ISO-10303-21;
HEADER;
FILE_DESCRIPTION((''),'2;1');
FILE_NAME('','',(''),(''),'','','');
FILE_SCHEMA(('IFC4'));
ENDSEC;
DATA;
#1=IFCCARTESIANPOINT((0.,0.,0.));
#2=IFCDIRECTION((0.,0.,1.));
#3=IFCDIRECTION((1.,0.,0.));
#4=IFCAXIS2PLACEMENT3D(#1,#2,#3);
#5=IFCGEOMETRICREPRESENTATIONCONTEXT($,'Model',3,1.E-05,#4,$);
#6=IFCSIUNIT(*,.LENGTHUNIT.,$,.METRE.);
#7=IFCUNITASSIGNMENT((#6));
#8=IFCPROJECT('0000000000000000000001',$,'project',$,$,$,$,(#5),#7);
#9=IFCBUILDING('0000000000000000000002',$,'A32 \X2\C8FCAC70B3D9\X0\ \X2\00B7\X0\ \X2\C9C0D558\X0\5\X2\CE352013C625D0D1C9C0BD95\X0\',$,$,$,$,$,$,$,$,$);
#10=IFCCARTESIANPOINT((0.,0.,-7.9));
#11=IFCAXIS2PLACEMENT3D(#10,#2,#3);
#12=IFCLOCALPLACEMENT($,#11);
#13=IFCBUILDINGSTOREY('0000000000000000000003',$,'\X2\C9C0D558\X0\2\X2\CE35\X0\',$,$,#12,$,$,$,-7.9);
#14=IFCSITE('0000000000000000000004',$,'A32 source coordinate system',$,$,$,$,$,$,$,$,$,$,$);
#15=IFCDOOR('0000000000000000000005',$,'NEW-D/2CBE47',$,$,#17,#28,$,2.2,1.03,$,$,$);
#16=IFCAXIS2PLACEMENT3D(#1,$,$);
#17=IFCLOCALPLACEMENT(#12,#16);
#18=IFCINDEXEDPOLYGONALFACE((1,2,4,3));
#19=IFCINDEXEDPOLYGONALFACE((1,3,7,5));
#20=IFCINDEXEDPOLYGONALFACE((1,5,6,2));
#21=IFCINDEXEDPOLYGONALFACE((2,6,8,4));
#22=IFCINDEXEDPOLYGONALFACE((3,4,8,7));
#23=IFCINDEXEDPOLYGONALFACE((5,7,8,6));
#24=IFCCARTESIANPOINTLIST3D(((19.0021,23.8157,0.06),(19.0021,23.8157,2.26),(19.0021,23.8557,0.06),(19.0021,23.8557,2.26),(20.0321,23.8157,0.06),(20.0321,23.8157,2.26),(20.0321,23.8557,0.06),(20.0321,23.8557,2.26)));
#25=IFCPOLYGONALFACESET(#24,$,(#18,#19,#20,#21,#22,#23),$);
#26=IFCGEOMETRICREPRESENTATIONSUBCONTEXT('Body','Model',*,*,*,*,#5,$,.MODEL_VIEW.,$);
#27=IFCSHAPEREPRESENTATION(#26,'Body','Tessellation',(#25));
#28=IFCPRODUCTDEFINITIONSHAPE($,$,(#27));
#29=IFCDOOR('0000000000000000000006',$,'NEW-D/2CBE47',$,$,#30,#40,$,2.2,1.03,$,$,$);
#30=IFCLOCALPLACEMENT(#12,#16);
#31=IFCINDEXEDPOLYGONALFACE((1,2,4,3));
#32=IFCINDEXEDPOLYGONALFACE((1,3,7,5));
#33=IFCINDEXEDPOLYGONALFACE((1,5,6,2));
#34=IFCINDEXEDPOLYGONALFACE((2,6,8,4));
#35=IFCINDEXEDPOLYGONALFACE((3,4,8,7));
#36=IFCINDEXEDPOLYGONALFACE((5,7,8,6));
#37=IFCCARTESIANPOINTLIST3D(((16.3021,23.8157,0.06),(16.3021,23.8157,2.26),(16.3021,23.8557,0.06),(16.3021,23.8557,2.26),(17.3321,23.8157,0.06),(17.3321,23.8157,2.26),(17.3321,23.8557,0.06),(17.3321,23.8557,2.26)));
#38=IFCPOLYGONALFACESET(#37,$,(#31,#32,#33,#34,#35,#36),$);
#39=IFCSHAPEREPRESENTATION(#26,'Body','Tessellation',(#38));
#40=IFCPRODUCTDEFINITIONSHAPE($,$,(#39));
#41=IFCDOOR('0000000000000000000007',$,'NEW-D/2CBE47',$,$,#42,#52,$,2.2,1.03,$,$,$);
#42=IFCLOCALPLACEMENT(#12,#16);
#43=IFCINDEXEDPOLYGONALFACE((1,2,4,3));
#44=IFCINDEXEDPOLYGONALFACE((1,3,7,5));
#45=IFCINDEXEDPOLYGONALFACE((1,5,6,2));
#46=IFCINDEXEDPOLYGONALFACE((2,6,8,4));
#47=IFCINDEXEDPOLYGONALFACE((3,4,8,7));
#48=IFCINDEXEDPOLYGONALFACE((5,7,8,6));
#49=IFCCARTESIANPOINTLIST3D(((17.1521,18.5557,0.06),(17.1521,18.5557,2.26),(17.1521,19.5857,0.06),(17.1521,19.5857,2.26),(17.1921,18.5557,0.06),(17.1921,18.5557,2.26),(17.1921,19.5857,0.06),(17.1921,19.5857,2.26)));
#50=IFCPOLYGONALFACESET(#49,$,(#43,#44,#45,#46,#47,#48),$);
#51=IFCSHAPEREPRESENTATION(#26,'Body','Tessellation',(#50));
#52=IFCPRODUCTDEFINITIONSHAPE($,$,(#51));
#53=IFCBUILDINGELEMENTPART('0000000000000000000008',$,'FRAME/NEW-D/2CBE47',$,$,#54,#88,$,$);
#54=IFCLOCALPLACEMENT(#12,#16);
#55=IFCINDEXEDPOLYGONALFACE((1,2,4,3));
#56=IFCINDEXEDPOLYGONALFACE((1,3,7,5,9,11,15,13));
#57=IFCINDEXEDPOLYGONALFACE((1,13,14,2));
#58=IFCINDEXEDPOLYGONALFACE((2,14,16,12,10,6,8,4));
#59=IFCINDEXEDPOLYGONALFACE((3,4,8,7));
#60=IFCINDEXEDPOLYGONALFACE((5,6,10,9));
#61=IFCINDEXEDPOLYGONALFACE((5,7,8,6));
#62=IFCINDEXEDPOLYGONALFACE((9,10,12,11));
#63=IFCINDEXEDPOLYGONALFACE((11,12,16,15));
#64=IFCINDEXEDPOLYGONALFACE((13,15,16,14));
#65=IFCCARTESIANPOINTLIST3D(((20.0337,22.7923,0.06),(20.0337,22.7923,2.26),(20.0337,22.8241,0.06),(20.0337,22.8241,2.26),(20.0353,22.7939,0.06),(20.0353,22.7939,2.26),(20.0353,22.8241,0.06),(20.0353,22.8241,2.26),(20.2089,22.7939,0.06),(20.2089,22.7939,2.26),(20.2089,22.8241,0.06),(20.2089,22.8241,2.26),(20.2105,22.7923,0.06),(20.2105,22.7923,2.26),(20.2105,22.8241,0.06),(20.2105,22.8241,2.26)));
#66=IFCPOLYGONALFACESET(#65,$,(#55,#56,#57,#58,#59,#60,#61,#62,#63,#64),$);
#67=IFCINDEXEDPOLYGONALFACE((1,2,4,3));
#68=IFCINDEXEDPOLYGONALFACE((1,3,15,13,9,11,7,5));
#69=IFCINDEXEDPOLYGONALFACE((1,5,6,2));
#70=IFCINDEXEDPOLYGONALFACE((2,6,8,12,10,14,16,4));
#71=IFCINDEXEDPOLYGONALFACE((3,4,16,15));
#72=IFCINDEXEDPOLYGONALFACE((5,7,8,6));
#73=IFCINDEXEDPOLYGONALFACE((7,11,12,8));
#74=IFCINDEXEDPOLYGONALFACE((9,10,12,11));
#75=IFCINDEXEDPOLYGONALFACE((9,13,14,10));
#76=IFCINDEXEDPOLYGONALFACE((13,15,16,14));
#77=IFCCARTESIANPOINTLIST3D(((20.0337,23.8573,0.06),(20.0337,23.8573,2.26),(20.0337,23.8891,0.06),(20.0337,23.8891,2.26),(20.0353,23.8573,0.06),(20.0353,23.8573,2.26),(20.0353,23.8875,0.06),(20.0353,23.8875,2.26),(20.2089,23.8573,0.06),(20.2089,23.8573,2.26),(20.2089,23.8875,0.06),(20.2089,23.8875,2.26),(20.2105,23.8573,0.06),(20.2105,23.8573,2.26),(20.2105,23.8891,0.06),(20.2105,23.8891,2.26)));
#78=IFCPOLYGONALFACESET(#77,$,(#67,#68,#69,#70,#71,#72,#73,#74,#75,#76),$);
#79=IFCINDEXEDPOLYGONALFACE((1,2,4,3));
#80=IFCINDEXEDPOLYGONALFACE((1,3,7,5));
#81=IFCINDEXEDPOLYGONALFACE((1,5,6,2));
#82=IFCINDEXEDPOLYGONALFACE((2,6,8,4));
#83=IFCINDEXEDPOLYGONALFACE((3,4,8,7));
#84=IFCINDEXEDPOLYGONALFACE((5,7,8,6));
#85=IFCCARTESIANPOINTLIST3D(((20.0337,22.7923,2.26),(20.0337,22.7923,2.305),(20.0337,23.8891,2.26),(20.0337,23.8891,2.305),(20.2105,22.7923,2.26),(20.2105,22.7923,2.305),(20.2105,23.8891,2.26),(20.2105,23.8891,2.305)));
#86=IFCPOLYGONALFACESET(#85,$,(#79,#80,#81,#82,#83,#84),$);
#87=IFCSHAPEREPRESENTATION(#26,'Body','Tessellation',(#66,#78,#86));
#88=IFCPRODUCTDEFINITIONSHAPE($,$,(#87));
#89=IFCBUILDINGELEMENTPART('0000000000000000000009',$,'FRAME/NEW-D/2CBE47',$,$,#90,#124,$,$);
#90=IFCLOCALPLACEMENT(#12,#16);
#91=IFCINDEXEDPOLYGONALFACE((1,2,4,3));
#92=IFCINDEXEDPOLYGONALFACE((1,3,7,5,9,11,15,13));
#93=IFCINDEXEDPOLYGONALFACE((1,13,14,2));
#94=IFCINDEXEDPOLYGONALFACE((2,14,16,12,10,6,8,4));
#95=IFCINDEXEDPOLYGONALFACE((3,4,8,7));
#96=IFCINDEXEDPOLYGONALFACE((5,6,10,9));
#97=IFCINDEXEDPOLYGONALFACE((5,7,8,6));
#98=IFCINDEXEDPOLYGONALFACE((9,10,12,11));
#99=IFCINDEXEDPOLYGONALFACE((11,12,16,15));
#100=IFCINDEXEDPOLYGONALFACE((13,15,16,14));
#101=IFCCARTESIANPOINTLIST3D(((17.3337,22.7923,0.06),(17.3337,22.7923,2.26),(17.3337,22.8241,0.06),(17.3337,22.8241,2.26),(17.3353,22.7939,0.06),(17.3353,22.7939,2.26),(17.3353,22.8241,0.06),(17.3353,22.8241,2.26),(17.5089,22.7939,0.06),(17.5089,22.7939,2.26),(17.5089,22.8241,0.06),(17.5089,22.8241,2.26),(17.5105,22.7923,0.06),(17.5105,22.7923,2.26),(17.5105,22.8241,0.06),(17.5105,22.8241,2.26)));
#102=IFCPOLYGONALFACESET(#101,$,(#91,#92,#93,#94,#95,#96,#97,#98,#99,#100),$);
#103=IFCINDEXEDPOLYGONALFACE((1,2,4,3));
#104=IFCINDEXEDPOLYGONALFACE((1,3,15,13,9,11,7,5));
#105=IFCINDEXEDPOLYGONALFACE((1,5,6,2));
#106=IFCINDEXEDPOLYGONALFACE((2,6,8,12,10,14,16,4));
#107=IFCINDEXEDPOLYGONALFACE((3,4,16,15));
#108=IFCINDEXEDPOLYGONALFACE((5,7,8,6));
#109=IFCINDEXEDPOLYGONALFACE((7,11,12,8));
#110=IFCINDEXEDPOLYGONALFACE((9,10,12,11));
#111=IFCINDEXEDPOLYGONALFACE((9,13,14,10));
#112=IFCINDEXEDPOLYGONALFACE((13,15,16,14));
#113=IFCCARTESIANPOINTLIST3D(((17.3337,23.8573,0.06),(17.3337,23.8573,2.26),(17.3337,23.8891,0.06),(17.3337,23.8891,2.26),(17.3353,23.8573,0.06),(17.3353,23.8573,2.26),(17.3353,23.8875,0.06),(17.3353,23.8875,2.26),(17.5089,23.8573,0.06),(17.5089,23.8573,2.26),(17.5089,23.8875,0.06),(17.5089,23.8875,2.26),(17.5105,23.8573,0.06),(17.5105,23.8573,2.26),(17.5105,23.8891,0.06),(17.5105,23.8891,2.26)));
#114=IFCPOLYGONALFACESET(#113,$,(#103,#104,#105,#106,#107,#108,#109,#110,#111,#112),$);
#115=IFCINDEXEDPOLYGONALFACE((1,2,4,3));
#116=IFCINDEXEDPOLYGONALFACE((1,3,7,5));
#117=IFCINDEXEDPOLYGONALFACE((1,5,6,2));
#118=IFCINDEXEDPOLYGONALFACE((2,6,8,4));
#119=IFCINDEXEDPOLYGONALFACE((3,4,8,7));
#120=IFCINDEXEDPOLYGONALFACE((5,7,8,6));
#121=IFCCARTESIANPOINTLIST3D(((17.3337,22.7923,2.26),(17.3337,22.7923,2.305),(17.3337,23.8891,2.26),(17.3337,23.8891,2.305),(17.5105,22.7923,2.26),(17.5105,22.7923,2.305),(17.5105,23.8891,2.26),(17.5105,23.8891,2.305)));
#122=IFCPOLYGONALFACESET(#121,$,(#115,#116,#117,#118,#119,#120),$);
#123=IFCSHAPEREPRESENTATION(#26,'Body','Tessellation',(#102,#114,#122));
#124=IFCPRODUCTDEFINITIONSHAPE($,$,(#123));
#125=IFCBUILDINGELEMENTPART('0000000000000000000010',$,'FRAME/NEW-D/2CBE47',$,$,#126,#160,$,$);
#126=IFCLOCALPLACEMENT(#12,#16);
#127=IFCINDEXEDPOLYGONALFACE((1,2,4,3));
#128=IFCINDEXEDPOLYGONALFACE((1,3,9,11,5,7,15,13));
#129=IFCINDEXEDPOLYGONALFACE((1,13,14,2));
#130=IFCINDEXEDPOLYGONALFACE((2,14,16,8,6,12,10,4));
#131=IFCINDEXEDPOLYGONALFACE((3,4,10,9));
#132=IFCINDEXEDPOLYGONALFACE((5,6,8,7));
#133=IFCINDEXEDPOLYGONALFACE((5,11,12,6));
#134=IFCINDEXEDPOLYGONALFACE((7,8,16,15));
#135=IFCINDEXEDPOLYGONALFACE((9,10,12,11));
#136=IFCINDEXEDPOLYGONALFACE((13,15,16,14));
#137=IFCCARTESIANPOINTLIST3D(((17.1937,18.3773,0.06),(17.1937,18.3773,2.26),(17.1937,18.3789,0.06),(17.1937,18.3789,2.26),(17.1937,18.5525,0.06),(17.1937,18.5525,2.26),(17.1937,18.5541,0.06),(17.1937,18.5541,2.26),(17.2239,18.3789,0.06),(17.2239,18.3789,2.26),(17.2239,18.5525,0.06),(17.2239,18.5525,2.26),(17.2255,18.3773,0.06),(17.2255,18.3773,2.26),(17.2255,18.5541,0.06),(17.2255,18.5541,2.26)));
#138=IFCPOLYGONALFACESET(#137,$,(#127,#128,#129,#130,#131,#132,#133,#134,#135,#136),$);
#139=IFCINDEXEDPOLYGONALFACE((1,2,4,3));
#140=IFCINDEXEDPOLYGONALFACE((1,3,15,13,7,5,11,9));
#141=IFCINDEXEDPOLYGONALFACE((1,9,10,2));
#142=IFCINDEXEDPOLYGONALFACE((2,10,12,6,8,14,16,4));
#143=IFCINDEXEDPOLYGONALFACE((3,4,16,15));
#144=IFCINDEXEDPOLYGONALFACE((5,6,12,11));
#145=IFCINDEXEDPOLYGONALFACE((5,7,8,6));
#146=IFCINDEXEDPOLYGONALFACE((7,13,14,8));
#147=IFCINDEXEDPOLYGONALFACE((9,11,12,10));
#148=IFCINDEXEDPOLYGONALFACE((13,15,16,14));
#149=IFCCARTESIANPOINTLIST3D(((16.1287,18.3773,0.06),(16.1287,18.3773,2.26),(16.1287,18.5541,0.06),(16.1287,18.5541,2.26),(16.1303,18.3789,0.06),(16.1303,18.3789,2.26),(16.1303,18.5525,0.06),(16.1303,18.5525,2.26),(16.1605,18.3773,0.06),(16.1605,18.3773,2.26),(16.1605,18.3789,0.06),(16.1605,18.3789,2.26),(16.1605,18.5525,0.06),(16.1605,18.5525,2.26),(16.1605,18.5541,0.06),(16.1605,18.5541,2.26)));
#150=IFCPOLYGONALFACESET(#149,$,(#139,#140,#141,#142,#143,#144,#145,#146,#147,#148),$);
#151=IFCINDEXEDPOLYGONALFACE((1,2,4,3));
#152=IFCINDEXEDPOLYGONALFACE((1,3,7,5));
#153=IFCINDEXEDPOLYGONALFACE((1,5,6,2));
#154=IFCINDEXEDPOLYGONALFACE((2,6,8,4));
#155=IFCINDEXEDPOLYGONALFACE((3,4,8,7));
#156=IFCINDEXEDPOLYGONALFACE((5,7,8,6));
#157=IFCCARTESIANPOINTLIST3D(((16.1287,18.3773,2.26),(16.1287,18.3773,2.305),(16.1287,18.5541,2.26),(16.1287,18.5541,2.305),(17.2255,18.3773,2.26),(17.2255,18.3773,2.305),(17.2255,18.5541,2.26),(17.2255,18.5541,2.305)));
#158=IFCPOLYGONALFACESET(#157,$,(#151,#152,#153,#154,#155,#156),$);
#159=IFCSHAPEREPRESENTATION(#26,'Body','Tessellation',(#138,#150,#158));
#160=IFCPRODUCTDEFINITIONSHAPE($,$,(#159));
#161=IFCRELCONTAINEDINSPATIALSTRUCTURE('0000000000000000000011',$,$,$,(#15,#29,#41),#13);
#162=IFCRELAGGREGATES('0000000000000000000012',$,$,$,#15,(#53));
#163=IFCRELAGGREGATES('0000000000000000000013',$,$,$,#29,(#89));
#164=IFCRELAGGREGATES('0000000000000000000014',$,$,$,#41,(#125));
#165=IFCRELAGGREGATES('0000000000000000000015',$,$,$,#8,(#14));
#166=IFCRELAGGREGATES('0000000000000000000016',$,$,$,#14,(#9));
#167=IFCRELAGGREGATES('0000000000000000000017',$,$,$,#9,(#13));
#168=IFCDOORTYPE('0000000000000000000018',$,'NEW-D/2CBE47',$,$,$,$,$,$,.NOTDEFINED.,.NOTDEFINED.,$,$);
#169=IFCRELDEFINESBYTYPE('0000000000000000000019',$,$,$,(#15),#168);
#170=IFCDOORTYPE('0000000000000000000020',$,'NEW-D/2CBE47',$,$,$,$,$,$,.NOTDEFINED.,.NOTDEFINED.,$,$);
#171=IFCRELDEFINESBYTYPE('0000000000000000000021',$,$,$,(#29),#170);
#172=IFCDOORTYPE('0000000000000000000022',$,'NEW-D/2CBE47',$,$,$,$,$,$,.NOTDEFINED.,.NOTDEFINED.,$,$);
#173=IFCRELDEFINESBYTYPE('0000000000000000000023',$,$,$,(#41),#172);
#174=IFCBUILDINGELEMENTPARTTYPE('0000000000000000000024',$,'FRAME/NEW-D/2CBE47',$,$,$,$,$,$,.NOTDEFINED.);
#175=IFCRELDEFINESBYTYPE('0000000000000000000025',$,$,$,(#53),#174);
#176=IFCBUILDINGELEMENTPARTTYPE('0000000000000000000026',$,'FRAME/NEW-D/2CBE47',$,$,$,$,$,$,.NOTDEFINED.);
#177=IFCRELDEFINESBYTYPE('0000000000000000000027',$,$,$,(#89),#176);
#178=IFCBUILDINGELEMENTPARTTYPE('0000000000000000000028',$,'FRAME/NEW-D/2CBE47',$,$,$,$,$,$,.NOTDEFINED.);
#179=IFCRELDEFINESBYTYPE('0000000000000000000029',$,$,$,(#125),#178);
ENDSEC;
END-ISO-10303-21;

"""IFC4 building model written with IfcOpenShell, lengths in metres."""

from ifc_helpers import new_model, si_unit, frame, origin, origin_with_axes, place, context, subcontext, project, spatial, polyline, outline, extrude, source, transform, mapped, type_object, type_shapes, element, aggregate, save


model = new_model("IFC4")

# Units and contexts
model_context = context("Model", 3, precision=1e-05, world=origin_with_axes())
body_context = subcontext(model_context, "Body", "Model", "MODEL_VIEW")
ifc_project = project(units=[si_unit("LENGTHUNIT", "METRE")], contexts=[model_context])

# Site, building, storey
site = spatial("IfcSite", under=ifc_project, Name="A32 source coordinate system")
building = spatial("IfcBuilding", under=site, Name="A32 주거동 · 지하5층–옥탑지붕")
storey_placement = place(None, frame((0.0, 0.0, -7.9), z_axis=(0.0, 0.0, 1.0), x_axis=(1.0, 0.0, 0.0)))
storey = spatial("IfcBuildingStorey", under=building, at=storey_placement, Name="지하2층", Elevation=-7.9)

# Doors
door_type_1 = type_object("IfcDoorType", Name="NEW-D/2CBE47", OperationType="NOTDEFINED", PredefinedType="NOTDEFINED")
shared_shape_1 = source(origin(), body_context, "Body", "SweptSolid", [
    extrude(outline(polyline([(20.0321, 23.8557), (20.0321, 23.8157), (19.0021, 23.8157), (19.0021, 23.8557), (20.0321, 23.8557)])), frame((0.0, 0.0, 0.06)), (0.0, 0.0, 1.0), 2.2),
])
type_shapes(door_type_1, [shared_shape_1])
door_1_placement = place(storey_placement, origin_with_axes())
door_1 = element("IfcDoor", 1, at=door_1_placement, inside=storey, type_object=door_type_1, Name="NEW-D/2CBE47", OverallHeight=2.2, OverallWidth=1.03, context=body_context, shape_type="MappedRepresentation", body=[
    mapped(shared_shape_1, transform((0.0, 0.0, 0.0), scale=1.0)),
])
door_type_2 = type_object("IfcDoorType", Name="NEW-D/2CBE47", OperationType="NOTDEFINED", PredefinedType="NOTDEFINED")
shared_shape_2 = source(origin(), body_context, "Body", "SweptSolid", [
    extrude(outline(polyline([(17.3321, 23.8557), (17.3321, 23.8157), (16.3021, 23.8157), (16.3021, 23.8557), (17.3321, 23.8557)])), frame((0.0, 0.0, 0.06)), (0.0, 0.0, 1.0), 2.2),
])
type_shapes(door_type_2, [shared_shape_2])
door_2_placement = place(storey_placement, origin_with_axes())
door_2 = element("IfcDoor", 2, at=door_2_placement, inside=storey, type_object=door_type_2, Name="NEW-D/2CBE47", OverallHeight=2.2, OverallWidth=1.03, context=body_context, shape_type="MappedRepresentation", body=[
    mapped(shared_shape_2, transform((0.0, 0.0, 0.0), scale=1.0)),
])
door_type_3 = type_object("IfcDoorType", Name="NEW-D/2CBE47", OperationType="NOTDEFINED", PredefinedType="NOTDEFINED")
shared_shape_3 = source(origin(), body_context, "Body", "SweptSolid", [
    extrude(outline(polyline([(17.1921, 18.5557), (17.1521, 18.5557), (17.1521, 19.5857), (17.1921, 19.5857), (17.1921, 18.5557)])), frame((0.0, 0.0, 0.06)), (0.0, 0.0, 1.0), 2.2),
])
type_shapes(door_type_3, [shared_shape_3])
door_3_placement = place(storey_placement, origin_with_axes())
door_3 = element("IfcDoor", 3, at=door_3_placement, inside=storey, type_object=door_type_3, Name="NEW-D/2CBE47", OverallHeight=2.2, OverallWidth=1.03, context=body_context, shape_type="MappedRepresentation", body=[
    mapped(shared_shape_3, transform((0.0, 0.0, 0.0), scale=1.0)),
])

# Building element parts
building_element_part_type_1 = type_object("IfcBuildingElementPartType", Name="FRAME/NEW-D/2CBE47", PredefinedType="NOTDEFINED")
shared_shape_4 = source(origin(), body_context, "Body", "SweptSolid", [
    extrude(outline(polyline([(20.0353, 22.7939), (20.2089, 22.7939), (20.2089, 22.8241), (20.2105, 22.8241), (20.2105, 22.7923), (20.0337, 22.7923), (20.0337, 22.8241), (20.0353, 22.8241), (20.0353, 22.7939)])), frame((0.0, 0.0, 0.06)), (0.0, 0.0, 1.0), 2.2),
    extrude(outline(polyline([(20.2105, 23.8891), (20.2105, 23.8573), (20.2089, 23.8573), (20.2089, 23.8875), (20.0353, 23.8875), (20.0353, 23.8573), (20.0337, 23.8573), (20.0337, 23.8891), (20.2105, 23.8891)])), frame((0.0, 0.0, 0.06)), (0.0, 0.0, 1.0), 2.2),
    extrude(outline(polyline([(20.2105, 22.7923), (20.2105, 23.8891), (20.0337, 23.8891), (20.0337, 22.7923), (20.2105, 22.7923)])), frame((0.0, 0.0, 2.26)), (0.0, 0.0, 1.0), 0.045),
])
type_shapes(building_element_part_type_1, [shared_shape_4])
building_element_part_1_placement = place(door_1_placement, origin_with_axes())
building_element_part_1 = element("IfcBuildingElementPart", 4, at=building_element_part_1_placement, type_object=building_element_part_type_1, Name="FRAME/NEW-D/2CBE47", context=body_context, shape_type="MappedRepresentation", body=[
    mapped(shared_shape_4, transform((0.0, 0.0, 0.0), scale=1.0)),
])
aggregate(door_1, [building_element_part_1])
building_element_part_type_2 = type_object("IfcBuildingElementPartType", Name="FRAME/NEW-D/2CBE47", PredefinedType="NOTDEFINED")
shared_shape_5 = source(origin(), body_context, "Body", "SweptSolid", [
    extrude(outline(polyline([(17.3353, 22.7939), (17.5089, 22.7939), (17.5089, 22.8241), (17.5105, 22.8241), (17.5105, 22.7923), (17.3337, 22.7923), (17.3337, 22.8241), (17.3353, 22.8241), (17.3353, 22.7939)])), frame((0.0, 0.0, 0.06)), (0.0, 0.0, 1.0), 2.2),
    extrude(outline(polyline([(17.5105, 23.8891), (17.5105, 23.8573), (17.5089, 23.8573), (17.5089, 23.8875), (17.3353, 23.8875), (17.3353, 23.8573), (17.3337, 23.8573), (17.3337, 23.8891), (17.5105, 23.8891)])), frame((0.0, 0.0, 0.06)), (0.0, 0.0, 1.0), 2.2),
    extrude(outline(polyline([(17.5105, 22.7923), (17.5105, 23.8891), (17.3337, 23.8891), (17.3337, 22.7923), (17.5105, 22.7923)])), frame((0.0, 0.0, 2.26)), (0.0, 0.0, 1.0), 0.045),
])
type_shapes(building_element_part_type_2, [shared_shape_5])
building_element_part_2_placement = place(door_2_placement, origin_with_axes())
building_element_part_2 = element("IfcBuildingElementPart", 5, at=building_element_part_2_placement, type_object=building_element_part_type_2, Name="FRAME/NEW-D/2CBE47", context=body_context, shape_type="MappedRepresentation", body=[
    mapped(shared_shape_5, transform((0.0, 0.0, 0.0), scale=1.0)),
])
aggregate(door_2, [building_element_part_2])
building_element_part_type_3 = type_object("IfcBuildingElementPartType", Name="FRAME/NEW-D/2CBE47", PredefinedType="NOTDEFINED")
shared_shape_6 = source(origin(), body_context, "Body", "SweptSolid", [
    extrude(outline(polyline([(17.2255, 18.3773), (17.1937, 18.3773), (17.1937, 18.3789), (17.2239, 18.3789), (17.2239, 18.5525), (17.1937, 18.5525), (17.1937, 18.5541), (17.2255, 18.5541), (17.2255, 18.3773)])), frame((0.0, 0.0, 0.06)), (0.0, 0.0, 1.0), 2.2),
    extrude(outline(polyline([(16.1303, 18.5525), (16.1303, 18.3789), (16.1605, 18.3789), (16.1605, 18.3773), (16.1287, 18.3773), (16.1287, 18.5541), (16.1605, 18.5541), (16.1605, 18.5525), (16.1303, 18.5525)])), frame((0.0, 0.0, 0.06)), (0.0, 0.0, 1.0), 2.2),
    extrude(outline(polyline([(17.2255, 18.3773), (17.2255, 18.5541), (16.1287, 18.5541), (16.1287, 18.3773), (17.2255, 18.3773)])), frame((0.0, 0.0, 2.26)), (0.0, 0.0, 1.0), 0.045),
])
type_shapes(building_element_part_type_3, [shared_shape_6])
building_element_part_3_placement = place(door_3_placement, origin_with_axes())
building_element_part_3 = element("IfcBuildingElementPart", 6, at=building_element_part_3_placement, type_object=building_element_part_type_3, Name="FRAME/NEW-D/2CBE47", context=body_context, shape_type="MappedRepresentation", body=[
    mapped(shared_shape_6, transform((0.0, 0.0, 0.0), scale=1.0)),
])
aggregate(door_3, [building_element_part_3])

save(model, "model.ifc")
